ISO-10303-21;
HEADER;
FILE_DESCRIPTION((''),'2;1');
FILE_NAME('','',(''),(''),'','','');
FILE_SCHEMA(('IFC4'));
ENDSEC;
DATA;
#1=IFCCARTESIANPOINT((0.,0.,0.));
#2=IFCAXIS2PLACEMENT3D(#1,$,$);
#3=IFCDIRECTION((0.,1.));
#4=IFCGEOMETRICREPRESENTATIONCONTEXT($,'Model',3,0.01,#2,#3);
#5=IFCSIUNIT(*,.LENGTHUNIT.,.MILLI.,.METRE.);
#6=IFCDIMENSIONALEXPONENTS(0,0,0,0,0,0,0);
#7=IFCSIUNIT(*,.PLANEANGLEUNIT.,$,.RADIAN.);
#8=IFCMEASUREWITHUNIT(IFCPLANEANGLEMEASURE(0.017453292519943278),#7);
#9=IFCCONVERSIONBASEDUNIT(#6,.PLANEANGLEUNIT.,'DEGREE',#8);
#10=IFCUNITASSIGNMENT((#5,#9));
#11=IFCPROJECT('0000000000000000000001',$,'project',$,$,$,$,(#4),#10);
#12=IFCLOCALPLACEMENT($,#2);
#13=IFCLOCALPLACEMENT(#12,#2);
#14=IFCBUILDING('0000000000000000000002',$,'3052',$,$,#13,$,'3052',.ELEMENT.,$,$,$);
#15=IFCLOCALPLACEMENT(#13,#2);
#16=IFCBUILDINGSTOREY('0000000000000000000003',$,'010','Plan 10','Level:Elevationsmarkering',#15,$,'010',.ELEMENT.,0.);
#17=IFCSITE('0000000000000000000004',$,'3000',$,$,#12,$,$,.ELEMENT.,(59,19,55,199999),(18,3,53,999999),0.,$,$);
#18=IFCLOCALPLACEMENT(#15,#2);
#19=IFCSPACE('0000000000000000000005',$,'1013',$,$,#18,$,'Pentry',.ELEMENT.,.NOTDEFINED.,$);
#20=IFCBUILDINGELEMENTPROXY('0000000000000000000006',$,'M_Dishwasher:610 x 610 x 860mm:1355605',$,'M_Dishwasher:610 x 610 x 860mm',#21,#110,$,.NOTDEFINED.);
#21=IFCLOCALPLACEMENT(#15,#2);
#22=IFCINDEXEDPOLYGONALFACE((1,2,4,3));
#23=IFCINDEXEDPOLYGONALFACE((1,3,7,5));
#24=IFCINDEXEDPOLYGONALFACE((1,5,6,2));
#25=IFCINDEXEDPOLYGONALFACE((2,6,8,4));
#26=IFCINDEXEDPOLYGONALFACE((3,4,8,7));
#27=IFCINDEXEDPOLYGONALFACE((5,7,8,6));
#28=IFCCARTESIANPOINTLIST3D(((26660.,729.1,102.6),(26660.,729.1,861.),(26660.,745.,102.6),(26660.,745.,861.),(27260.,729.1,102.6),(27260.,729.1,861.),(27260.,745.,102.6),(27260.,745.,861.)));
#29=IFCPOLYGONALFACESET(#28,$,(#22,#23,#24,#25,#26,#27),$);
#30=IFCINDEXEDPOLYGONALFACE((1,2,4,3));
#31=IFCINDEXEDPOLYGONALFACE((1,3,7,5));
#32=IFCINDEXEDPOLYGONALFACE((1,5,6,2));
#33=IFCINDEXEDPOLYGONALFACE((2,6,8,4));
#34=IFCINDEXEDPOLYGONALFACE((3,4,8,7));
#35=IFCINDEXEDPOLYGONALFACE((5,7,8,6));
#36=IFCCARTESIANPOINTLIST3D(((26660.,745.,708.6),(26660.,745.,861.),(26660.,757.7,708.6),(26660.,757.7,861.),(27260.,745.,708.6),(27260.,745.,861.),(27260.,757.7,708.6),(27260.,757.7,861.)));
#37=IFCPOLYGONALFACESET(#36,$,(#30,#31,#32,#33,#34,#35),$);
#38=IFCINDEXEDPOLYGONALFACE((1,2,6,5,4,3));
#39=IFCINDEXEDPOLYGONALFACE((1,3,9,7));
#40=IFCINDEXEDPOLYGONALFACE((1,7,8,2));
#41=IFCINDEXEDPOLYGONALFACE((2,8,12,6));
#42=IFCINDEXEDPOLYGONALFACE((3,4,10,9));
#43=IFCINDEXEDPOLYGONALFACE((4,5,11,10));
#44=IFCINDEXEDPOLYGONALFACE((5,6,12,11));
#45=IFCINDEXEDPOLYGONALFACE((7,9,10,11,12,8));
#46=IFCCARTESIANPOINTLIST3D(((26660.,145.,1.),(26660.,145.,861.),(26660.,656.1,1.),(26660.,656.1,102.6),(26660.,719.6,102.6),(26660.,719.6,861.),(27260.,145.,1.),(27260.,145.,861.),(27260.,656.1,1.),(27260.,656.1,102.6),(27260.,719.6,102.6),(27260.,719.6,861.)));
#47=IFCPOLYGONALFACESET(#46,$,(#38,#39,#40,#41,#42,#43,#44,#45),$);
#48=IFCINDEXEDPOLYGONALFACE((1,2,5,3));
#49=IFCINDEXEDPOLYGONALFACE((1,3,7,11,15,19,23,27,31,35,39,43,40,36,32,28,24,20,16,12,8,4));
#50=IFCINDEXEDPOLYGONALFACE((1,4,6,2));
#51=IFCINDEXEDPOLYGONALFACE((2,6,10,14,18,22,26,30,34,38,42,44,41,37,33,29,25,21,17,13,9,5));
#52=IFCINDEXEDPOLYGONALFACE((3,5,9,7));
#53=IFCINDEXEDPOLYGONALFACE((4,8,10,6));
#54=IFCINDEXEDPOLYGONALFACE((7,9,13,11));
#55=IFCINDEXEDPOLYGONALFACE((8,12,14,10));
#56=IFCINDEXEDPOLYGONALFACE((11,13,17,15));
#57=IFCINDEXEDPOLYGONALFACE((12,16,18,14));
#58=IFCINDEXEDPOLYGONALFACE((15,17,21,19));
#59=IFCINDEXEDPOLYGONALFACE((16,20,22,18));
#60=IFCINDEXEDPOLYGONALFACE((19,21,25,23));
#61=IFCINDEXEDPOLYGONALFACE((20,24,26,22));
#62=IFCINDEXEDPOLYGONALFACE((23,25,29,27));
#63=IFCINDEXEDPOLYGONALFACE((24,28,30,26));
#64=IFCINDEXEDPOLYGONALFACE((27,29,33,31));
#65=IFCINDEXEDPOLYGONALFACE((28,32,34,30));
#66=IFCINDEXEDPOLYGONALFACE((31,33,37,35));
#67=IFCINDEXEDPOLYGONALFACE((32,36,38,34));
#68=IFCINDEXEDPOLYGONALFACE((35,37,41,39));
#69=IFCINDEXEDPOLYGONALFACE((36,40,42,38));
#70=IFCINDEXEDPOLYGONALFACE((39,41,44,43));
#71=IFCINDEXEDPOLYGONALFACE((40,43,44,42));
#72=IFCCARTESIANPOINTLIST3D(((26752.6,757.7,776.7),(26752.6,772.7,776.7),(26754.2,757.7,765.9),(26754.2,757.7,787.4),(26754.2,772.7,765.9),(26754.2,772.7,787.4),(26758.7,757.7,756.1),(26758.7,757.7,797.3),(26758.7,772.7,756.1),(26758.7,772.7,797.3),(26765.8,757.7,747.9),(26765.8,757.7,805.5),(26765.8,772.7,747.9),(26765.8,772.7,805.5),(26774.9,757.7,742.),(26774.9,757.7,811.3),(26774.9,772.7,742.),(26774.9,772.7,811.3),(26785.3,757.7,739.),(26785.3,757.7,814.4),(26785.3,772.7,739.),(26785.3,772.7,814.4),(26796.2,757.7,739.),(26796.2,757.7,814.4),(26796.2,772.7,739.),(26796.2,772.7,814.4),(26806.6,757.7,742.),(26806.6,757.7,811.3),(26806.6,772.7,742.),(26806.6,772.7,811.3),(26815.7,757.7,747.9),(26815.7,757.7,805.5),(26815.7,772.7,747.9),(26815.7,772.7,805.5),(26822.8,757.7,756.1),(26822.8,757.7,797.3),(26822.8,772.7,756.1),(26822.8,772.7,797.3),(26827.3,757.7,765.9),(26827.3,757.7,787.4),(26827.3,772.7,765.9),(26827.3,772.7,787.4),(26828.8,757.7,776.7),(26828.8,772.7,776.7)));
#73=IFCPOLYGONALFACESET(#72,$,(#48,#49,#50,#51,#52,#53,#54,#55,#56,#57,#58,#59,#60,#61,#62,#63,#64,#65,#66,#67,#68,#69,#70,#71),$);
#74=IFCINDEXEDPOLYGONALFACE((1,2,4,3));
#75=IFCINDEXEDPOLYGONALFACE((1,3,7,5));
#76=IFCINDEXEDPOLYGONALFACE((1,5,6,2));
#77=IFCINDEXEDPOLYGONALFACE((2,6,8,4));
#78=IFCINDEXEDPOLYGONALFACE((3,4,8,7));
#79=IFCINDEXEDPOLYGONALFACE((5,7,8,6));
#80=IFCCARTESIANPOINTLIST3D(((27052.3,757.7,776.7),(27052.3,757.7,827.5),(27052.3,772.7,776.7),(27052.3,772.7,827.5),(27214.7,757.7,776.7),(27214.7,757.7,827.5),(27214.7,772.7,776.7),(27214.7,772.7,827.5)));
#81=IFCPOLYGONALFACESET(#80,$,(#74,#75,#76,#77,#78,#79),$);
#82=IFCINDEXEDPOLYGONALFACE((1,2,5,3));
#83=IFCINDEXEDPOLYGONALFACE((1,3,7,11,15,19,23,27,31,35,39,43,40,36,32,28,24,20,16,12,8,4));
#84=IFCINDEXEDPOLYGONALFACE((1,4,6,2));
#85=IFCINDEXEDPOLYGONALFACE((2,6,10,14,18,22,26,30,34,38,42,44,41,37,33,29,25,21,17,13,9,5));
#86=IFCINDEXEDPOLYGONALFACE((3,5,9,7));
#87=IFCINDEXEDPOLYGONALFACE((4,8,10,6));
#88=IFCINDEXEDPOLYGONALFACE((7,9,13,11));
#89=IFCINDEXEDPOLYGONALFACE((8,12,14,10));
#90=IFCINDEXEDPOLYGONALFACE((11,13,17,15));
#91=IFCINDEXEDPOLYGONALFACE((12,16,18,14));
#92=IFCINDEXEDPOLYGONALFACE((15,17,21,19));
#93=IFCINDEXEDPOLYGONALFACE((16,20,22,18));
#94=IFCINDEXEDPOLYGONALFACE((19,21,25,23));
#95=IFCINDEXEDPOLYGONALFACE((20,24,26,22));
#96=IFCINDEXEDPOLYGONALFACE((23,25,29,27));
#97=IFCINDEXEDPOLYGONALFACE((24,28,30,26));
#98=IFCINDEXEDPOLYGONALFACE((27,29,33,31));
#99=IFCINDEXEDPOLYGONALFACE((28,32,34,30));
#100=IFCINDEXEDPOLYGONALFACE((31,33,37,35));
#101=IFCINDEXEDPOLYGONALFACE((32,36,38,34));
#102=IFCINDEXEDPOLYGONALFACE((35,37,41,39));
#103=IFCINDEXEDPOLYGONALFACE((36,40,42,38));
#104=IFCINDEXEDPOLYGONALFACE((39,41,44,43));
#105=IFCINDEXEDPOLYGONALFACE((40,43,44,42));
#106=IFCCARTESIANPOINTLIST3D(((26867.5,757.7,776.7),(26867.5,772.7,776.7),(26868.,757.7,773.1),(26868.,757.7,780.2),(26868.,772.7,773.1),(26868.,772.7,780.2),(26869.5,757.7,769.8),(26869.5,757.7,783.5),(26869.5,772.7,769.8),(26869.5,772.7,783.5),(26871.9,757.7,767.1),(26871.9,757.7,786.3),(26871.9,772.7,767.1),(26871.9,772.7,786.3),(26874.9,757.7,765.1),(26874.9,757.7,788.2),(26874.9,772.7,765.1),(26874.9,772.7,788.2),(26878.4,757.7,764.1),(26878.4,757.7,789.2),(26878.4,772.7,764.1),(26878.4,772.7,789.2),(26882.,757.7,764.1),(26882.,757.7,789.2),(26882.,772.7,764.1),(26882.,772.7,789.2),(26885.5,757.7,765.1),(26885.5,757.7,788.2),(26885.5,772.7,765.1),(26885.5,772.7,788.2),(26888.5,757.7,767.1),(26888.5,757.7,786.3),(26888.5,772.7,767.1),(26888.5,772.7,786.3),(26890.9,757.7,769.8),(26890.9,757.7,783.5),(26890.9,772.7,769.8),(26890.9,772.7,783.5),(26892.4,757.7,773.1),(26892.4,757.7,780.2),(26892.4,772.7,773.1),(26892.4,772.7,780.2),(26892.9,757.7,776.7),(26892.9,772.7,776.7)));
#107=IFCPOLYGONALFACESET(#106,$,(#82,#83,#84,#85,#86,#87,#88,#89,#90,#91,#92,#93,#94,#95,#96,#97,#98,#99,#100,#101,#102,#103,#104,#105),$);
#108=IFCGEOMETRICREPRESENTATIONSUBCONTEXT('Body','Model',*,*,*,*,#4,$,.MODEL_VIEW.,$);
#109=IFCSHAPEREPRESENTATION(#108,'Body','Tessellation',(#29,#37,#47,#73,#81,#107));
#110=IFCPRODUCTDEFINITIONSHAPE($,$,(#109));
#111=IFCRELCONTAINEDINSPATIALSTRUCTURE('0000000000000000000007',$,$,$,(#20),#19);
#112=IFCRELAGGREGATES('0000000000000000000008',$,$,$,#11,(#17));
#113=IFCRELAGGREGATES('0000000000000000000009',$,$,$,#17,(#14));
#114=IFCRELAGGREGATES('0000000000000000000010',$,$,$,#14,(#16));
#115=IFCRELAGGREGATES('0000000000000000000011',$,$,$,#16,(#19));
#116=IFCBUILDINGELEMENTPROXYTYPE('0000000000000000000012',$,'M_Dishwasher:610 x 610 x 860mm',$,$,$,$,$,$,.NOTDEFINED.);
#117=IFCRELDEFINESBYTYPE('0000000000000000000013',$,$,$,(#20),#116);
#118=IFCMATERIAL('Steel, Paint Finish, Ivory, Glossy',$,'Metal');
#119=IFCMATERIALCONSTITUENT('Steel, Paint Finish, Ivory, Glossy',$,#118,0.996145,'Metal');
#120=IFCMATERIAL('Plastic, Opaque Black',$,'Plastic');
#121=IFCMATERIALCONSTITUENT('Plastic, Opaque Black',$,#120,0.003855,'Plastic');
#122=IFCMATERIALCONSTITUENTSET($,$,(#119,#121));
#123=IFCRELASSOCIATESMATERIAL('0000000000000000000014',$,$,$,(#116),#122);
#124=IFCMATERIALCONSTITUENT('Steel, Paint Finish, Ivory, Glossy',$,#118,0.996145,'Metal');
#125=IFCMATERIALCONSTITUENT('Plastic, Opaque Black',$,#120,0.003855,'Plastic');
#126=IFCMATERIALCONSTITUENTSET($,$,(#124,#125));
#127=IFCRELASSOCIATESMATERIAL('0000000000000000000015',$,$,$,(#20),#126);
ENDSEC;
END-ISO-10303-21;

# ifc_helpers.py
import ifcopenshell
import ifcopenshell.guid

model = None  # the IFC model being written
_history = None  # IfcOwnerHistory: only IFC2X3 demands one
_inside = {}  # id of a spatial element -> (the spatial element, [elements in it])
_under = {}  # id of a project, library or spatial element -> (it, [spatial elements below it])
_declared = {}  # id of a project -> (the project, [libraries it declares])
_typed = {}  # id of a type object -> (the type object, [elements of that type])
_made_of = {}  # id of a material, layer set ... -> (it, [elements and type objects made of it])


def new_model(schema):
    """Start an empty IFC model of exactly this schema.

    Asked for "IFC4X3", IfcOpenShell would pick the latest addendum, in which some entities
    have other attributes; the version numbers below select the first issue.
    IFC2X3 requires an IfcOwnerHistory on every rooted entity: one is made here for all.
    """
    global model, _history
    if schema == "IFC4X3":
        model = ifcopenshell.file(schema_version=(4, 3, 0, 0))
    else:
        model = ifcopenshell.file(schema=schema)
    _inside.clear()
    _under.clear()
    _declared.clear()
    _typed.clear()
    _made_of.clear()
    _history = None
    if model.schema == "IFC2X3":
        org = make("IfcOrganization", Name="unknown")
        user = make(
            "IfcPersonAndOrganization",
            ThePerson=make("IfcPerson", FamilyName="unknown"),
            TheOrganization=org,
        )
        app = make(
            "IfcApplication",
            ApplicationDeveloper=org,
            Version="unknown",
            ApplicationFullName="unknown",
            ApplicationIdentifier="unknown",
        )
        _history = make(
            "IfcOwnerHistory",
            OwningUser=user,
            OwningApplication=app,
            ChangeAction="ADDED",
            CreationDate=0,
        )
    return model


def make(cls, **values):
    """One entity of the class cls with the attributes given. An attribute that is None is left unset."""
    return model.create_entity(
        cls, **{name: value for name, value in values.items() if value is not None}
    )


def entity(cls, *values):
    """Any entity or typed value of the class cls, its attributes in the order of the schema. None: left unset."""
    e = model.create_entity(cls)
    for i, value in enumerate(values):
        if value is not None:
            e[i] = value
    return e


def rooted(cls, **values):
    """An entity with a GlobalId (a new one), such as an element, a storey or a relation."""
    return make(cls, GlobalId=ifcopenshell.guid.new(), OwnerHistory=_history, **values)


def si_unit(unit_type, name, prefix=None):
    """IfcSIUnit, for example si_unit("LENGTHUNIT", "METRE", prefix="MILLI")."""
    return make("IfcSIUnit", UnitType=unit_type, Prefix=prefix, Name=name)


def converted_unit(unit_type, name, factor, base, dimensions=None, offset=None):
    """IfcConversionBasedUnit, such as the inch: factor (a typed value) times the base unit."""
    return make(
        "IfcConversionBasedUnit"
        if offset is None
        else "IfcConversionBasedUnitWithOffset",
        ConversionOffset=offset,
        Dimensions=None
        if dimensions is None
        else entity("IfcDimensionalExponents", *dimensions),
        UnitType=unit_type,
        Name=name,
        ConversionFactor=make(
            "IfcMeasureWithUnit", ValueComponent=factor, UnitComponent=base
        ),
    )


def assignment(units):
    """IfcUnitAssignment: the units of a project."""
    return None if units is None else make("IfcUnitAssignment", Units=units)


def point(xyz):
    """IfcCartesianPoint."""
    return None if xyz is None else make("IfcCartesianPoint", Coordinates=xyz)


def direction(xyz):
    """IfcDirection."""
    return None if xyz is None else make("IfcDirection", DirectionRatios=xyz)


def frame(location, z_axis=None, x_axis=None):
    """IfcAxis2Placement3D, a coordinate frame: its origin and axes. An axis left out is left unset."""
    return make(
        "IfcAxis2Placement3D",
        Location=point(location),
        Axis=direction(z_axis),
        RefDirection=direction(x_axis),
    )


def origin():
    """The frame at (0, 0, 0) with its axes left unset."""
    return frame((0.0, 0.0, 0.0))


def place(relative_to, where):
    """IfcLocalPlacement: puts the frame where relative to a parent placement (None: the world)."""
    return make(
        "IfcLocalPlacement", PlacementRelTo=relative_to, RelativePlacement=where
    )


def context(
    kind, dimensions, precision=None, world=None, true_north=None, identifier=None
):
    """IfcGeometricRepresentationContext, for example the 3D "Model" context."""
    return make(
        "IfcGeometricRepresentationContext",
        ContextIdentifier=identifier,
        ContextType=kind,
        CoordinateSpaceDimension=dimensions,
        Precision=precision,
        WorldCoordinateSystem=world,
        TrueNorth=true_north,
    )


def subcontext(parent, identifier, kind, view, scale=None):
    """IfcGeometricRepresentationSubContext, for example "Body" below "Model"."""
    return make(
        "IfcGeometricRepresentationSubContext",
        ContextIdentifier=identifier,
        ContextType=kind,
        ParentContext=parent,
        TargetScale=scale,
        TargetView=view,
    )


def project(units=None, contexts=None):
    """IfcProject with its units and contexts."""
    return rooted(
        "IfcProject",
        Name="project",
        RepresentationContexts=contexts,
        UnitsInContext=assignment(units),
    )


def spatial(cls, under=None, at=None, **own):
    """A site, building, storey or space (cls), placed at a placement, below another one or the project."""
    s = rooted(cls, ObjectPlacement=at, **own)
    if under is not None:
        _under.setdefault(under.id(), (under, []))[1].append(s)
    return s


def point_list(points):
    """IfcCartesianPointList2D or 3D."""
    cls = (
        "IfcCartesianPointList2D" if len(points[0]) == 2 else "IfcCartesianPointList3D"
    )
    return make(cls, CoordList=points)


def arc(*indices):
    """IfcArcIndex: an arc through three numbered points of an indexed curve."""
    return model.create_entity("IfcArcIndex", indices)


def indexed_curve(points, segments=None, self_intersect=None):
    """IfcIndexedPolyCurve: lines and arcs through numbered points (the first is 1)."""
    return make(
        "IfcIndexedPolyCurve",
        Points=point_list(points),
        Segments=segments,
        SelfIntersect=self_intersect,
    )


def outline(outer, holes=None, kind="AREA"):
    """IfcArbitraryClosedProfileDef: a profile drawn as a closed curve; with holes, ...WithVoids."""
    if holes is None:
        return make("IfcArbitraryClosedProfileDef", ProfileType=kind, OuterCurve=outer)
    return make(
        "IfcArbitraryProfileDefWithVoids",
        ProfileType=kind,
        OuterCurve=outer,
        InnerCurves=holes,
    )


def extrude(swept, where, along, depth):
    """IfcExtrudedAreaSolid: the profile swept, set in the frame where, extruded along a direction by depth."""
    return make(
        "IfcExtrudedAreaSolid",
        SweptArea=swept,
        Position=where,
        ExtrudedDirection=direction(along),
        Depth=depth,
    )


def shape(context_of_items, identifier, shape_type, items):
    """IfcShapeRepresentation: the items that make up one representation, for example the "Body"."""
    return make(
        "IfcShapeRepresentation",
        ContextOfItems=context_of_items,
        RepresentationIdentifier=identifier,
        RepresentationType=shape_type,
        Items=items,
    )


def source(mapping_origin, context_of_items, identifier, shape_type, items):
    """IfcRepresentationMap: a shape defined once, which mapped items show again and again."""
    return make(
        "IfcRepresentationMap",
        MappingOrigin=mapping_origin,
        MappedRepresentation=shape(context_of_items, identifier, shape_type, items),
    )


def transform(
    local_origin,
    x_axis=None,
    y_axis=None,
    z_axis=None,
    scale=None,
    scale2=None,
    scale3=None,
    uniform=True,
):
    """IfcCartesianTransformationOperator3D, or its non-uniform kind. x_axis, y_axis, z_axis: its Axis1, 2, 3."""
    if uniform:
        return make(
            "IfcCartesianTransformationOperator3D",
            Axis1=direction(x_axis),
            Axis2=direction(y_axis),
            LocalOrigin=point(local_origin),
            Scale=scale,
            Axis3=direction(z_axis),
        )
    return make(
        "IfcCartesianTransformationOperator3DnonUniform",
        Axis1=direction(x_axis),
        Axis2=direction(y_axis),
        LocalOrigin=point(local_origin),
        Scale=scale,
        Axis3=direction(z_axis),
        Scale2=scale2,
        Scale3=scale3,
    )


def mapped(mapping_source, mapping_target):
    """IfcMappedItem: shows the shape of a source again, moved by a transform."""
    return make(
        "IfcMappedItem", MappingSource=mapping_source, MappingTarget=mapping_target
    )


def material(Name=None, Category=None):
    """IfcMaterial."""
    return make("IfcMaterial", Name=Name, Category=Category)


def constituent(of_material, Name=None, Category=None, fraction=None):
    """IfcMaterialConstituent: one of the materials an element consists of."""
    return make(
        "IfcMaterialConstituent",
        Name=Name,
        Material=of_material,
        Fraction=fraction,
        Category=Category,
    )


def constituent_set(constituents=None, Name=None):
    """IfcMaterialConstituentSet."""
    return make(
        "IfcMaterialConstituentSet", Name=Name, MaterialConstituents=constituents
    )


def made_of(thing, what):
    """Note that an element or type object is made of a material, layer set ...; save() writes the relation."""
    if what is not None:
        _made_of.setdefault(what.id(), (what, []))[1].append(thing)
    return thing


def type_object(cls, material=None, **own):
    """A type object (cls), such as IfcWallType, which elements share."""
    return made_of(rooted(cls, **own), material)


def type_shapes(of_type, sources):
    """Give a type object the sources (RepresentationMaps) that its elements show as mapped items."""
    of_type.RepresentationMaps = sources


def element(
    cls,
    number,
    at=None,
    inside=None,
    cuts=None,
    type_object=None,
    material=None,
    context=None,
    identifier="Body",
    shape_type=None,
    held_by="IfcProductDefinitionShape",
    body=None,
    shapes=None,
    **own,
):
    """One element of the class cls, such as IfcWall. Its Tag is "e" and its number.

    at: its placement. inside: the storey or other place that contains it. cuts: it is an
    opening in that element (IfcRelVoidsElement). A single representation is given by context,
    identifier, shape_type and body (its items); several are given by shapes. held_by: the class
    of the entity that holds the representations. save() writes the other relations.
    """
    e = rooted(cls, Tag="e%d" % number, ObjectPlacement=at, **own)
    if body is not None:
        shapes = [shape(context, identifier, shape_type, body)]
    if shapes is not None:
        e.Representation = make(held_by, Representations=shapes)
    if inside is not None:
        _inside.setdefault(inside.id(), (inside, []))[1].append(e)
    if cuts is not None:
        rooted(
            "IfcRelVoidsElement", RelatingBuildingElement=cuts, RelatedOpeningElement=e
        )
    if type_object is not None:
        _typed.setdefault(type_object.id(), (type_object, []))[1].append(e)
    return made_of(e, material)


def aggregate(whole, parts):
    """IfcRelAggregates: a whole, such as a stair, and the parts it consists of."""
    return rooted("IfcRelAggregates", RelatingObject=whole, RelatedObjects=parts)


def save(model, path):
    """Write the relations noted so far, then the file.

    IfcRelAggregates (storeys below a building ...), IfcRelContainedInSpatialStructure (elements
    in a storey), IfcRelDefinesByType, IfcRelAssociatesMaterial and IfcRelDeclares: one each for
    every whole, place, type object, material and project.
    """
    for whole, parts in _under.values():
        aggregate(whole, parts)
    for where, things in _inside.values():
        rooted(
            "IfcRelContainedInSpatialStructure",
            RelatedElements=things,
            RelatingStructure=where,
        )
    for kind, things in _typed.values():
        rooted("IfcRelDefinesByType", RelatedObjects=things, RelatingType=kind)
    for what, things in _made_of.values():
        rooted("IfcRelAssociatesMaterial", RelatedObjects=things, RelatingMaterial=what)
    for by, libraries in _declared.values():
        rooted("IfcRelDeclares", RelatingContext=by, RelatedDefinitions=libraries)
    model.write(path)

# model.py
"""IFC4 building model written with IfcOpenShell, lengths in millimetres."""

from ifc_helpers import new_model, entity, si_unit, converted_unit, direction, frame, origin, place, context, subcontext, project, spatial, arc, indexed_curve, outline, extrude, source, transform, mapped, material, constituent, constituent_set, type_object, type_shapes, element, save


model = new_model("IFC4")

# Units and contexts
model_context = context("Model", 3, precision=0.01, world=origin(), true_north=direction((0.0, 1.0)))
body_context = subcontext(model_context, "Body", "Model", "MODEL_VIEW")
ifc_project = project(units=[si_unit("LENGTHUNIT", "METRE", prefix="MILLI"), converted_unit("PLANEANGLEUNIT", "DEGREE", entity("IfcPlaneAngleMeasure", 0.017453292519943278), si_unit("PLANEANGLEUNIT", "RADIAN"), dimensions=[0, 0, 0, 0, 0, 0, 0])], contexts=[model_context])

# Site, building, storey
site_placement = place(None, origin())
site = spatial("IfcSite", under=ifc_project, at=site_placement, Name="3000", CompositionType="ELEMENT", RefLatitude=(59, 19, 55, 199999), RefLongitude=(18, 3, 53, 999999), RefElevation=0.0)
building_placement = place(site_placement, origin())
building = spatial("IfcBuilding", under=site, at=building_placement, Name="3052", LongName="3052", CompositionType="ELEMENT")
storey_placement = place(building_placement, origin())
storey = spatial("IfcBuildingStorey", under=building, at=storey_placement, Name="010", Description="Plan 10", ObjectType="Level:Elevationsmarkering", LongName="010", CompositionType="ELEMENT", Elevation=0.0)

# Shared definitions
space_placement = place(storey_placement, origin())
space = spatial("IfcSpace", under=storey, at=space_placement, Name="1013", LongName="Pentry", CompositionType="ELEMENT", PredefinedType="NOTDEFINED")

# Building element proxy
ifc_material_1 = material(Name="Steel, Paint Finish, Ivory, Glossy", Category="Metal")
ifc_constituent_1 = constituent(ifc_material_1, Name="Steel, Paint Finish, Ivory, Glossy", Category="Metal", fraction=0.996145)
ifc_material_2 = material(Name="Plastic, Opaque Black", Category="Plastic")
ifc_constituent_2 = constituent(ifc_material_2, Name="Plastic, Opaque Black", Category="Plastic", fraction=0.003855)
ifc_constituent_set_1 = constituent_set(constituents=[ifc_constituent_1, ifc_constituent_2])
ifc_constituent_3 = constituent(ifc_material_1, Name="Steel, Paint Finish, Ivory, Glossy", Category="Metal", fraction=0.996145)
ifc_constituent_4 = constituent(ifc_material_2, Name="Plastic, Opaque Black", Category="Plastic", fraction=0.003855)
ifc_constituent_set_2 = constituent_set(constituents=[ifc_constituent_3, ifc_constituent_4])
building_element_proxy_type = type_object("IfcBuildingElementProxyType", Name="M_Dishwasher:610 x 610 x 860mm", PredefinedType="NOTDEFINED", material=ifc_constituent_set_2)
shared_shape_1 = source(origin(), body_context, "Body", "SweptSolid", [
    extrude(outline(indexed_curve([(-7.9, -300.0), (7.9, -300.0), (7.9, 300.0), (-7.9, 300.0), (-7.9, -300.0)], self_intersect=False)), frame((377.5, -30.4, 101.6), z_axis=(0.0, 0.0, 1.0), x_axis=(0.0, 1.0, 0.0)), (0.0, 0.0, 1.0), 758.4),
    extrude(outline(indexed_curve([(-300.0, -6.4), (300.0, -6.4), (300.0, 6.4), (-300.0, 6.4), (-300.0, -6.4)], self_intersect=False)), frame((377.5, -44.7, 707.6), z_axis=(0.0, 0.0, 1.0), x_axis=(-1.0, 0.0, 0.0)), (0.0, 0.0, 1.0), 152.4),
    extrude(outline(indexed_curve([(-320.5, -361.9), (539.5, -361.9), (539.5, 212.7), (-218.9, 212.7), (-218.9, 149.2), (-320.5, 149.2), (-320.5, -361.9)], self_intersect=False)), frame((77.5, 199.7, 320.5), z_axis=(1.0, 0.0, 0.0), x_axis=(0.0, 0.0, 1.0)), (0.0, 0.0, 1.0), 600.0),
    extrude(outline(indexed_curve([(-38.1, 0.0), (0.0, -38.1), (38.1, 0.0), (0.0, 38.1)], segments=[arc(1, 2, 3), arc(3, 4, 1)], self_intersect=False)), frame((546.8, -66.1, 775.7), z_axis=(0.0, 1.0, 0.0), x_axis=(-1.0, 0.0, 0.0)), (0.0, 0.0, 1.0), 15.0),
    extrude(outline(indexed_curve([(-7.5, -81.2), (7.5, -81.2), (7.5, 81.2), (-7.5, 81.2), (-7.5, -81.2)], self_intersect=False)), frame((204.0, -58.6, 775.7), z_axis=(0.0, 0.0, 1.0), x_axis=(0.0, 1.0, 0.0)), (0.0, 0.0, 1.0), 50.8),
    extrude(outline(indexed_curve([(-12.7, 0.0), (0.0, -12.7), (12.7, 0.0), (0.0, 12.7)], segments=[arc(1, 2, 3), arc(3, 4, 1)], self_intersect=False)), frame((457.3, -66.1, 775.7), z_axis=(0.0, 1.0, 0.0), x_axis=(-1.0, 0.0, 0.0)), (0.0, 0.0, 1.0), 15.0),
])
type_shapes(building_element_proxy_type, [shared_shape_1])
proxy_placement = place(space_placement, frame((27337.5, 706.6, 1.0), z_axis=(0.0, 0.0, 1.0), x_axis=(-1.0, 0.0, 0.0)))
element("IfcBuildingElementProxy", 1, at=proxy_placement, inside=space, type_object=building_element_proxy_type, material=ifc_constituent_set_1, Name="M_Dishwasher:610 x 610 x 860mm:1355605", ObjectType="M_Dishwasher:610 x 610 x 860mm", PredefinedType="NOTDEFINED", context=body_context, shape_type="MappedRepresentation", body=[
    mapped(shared_shape_1, transform((0.0, 0.0, 0.0), scale=1.0)),
])

save(model, "model.ifc")
